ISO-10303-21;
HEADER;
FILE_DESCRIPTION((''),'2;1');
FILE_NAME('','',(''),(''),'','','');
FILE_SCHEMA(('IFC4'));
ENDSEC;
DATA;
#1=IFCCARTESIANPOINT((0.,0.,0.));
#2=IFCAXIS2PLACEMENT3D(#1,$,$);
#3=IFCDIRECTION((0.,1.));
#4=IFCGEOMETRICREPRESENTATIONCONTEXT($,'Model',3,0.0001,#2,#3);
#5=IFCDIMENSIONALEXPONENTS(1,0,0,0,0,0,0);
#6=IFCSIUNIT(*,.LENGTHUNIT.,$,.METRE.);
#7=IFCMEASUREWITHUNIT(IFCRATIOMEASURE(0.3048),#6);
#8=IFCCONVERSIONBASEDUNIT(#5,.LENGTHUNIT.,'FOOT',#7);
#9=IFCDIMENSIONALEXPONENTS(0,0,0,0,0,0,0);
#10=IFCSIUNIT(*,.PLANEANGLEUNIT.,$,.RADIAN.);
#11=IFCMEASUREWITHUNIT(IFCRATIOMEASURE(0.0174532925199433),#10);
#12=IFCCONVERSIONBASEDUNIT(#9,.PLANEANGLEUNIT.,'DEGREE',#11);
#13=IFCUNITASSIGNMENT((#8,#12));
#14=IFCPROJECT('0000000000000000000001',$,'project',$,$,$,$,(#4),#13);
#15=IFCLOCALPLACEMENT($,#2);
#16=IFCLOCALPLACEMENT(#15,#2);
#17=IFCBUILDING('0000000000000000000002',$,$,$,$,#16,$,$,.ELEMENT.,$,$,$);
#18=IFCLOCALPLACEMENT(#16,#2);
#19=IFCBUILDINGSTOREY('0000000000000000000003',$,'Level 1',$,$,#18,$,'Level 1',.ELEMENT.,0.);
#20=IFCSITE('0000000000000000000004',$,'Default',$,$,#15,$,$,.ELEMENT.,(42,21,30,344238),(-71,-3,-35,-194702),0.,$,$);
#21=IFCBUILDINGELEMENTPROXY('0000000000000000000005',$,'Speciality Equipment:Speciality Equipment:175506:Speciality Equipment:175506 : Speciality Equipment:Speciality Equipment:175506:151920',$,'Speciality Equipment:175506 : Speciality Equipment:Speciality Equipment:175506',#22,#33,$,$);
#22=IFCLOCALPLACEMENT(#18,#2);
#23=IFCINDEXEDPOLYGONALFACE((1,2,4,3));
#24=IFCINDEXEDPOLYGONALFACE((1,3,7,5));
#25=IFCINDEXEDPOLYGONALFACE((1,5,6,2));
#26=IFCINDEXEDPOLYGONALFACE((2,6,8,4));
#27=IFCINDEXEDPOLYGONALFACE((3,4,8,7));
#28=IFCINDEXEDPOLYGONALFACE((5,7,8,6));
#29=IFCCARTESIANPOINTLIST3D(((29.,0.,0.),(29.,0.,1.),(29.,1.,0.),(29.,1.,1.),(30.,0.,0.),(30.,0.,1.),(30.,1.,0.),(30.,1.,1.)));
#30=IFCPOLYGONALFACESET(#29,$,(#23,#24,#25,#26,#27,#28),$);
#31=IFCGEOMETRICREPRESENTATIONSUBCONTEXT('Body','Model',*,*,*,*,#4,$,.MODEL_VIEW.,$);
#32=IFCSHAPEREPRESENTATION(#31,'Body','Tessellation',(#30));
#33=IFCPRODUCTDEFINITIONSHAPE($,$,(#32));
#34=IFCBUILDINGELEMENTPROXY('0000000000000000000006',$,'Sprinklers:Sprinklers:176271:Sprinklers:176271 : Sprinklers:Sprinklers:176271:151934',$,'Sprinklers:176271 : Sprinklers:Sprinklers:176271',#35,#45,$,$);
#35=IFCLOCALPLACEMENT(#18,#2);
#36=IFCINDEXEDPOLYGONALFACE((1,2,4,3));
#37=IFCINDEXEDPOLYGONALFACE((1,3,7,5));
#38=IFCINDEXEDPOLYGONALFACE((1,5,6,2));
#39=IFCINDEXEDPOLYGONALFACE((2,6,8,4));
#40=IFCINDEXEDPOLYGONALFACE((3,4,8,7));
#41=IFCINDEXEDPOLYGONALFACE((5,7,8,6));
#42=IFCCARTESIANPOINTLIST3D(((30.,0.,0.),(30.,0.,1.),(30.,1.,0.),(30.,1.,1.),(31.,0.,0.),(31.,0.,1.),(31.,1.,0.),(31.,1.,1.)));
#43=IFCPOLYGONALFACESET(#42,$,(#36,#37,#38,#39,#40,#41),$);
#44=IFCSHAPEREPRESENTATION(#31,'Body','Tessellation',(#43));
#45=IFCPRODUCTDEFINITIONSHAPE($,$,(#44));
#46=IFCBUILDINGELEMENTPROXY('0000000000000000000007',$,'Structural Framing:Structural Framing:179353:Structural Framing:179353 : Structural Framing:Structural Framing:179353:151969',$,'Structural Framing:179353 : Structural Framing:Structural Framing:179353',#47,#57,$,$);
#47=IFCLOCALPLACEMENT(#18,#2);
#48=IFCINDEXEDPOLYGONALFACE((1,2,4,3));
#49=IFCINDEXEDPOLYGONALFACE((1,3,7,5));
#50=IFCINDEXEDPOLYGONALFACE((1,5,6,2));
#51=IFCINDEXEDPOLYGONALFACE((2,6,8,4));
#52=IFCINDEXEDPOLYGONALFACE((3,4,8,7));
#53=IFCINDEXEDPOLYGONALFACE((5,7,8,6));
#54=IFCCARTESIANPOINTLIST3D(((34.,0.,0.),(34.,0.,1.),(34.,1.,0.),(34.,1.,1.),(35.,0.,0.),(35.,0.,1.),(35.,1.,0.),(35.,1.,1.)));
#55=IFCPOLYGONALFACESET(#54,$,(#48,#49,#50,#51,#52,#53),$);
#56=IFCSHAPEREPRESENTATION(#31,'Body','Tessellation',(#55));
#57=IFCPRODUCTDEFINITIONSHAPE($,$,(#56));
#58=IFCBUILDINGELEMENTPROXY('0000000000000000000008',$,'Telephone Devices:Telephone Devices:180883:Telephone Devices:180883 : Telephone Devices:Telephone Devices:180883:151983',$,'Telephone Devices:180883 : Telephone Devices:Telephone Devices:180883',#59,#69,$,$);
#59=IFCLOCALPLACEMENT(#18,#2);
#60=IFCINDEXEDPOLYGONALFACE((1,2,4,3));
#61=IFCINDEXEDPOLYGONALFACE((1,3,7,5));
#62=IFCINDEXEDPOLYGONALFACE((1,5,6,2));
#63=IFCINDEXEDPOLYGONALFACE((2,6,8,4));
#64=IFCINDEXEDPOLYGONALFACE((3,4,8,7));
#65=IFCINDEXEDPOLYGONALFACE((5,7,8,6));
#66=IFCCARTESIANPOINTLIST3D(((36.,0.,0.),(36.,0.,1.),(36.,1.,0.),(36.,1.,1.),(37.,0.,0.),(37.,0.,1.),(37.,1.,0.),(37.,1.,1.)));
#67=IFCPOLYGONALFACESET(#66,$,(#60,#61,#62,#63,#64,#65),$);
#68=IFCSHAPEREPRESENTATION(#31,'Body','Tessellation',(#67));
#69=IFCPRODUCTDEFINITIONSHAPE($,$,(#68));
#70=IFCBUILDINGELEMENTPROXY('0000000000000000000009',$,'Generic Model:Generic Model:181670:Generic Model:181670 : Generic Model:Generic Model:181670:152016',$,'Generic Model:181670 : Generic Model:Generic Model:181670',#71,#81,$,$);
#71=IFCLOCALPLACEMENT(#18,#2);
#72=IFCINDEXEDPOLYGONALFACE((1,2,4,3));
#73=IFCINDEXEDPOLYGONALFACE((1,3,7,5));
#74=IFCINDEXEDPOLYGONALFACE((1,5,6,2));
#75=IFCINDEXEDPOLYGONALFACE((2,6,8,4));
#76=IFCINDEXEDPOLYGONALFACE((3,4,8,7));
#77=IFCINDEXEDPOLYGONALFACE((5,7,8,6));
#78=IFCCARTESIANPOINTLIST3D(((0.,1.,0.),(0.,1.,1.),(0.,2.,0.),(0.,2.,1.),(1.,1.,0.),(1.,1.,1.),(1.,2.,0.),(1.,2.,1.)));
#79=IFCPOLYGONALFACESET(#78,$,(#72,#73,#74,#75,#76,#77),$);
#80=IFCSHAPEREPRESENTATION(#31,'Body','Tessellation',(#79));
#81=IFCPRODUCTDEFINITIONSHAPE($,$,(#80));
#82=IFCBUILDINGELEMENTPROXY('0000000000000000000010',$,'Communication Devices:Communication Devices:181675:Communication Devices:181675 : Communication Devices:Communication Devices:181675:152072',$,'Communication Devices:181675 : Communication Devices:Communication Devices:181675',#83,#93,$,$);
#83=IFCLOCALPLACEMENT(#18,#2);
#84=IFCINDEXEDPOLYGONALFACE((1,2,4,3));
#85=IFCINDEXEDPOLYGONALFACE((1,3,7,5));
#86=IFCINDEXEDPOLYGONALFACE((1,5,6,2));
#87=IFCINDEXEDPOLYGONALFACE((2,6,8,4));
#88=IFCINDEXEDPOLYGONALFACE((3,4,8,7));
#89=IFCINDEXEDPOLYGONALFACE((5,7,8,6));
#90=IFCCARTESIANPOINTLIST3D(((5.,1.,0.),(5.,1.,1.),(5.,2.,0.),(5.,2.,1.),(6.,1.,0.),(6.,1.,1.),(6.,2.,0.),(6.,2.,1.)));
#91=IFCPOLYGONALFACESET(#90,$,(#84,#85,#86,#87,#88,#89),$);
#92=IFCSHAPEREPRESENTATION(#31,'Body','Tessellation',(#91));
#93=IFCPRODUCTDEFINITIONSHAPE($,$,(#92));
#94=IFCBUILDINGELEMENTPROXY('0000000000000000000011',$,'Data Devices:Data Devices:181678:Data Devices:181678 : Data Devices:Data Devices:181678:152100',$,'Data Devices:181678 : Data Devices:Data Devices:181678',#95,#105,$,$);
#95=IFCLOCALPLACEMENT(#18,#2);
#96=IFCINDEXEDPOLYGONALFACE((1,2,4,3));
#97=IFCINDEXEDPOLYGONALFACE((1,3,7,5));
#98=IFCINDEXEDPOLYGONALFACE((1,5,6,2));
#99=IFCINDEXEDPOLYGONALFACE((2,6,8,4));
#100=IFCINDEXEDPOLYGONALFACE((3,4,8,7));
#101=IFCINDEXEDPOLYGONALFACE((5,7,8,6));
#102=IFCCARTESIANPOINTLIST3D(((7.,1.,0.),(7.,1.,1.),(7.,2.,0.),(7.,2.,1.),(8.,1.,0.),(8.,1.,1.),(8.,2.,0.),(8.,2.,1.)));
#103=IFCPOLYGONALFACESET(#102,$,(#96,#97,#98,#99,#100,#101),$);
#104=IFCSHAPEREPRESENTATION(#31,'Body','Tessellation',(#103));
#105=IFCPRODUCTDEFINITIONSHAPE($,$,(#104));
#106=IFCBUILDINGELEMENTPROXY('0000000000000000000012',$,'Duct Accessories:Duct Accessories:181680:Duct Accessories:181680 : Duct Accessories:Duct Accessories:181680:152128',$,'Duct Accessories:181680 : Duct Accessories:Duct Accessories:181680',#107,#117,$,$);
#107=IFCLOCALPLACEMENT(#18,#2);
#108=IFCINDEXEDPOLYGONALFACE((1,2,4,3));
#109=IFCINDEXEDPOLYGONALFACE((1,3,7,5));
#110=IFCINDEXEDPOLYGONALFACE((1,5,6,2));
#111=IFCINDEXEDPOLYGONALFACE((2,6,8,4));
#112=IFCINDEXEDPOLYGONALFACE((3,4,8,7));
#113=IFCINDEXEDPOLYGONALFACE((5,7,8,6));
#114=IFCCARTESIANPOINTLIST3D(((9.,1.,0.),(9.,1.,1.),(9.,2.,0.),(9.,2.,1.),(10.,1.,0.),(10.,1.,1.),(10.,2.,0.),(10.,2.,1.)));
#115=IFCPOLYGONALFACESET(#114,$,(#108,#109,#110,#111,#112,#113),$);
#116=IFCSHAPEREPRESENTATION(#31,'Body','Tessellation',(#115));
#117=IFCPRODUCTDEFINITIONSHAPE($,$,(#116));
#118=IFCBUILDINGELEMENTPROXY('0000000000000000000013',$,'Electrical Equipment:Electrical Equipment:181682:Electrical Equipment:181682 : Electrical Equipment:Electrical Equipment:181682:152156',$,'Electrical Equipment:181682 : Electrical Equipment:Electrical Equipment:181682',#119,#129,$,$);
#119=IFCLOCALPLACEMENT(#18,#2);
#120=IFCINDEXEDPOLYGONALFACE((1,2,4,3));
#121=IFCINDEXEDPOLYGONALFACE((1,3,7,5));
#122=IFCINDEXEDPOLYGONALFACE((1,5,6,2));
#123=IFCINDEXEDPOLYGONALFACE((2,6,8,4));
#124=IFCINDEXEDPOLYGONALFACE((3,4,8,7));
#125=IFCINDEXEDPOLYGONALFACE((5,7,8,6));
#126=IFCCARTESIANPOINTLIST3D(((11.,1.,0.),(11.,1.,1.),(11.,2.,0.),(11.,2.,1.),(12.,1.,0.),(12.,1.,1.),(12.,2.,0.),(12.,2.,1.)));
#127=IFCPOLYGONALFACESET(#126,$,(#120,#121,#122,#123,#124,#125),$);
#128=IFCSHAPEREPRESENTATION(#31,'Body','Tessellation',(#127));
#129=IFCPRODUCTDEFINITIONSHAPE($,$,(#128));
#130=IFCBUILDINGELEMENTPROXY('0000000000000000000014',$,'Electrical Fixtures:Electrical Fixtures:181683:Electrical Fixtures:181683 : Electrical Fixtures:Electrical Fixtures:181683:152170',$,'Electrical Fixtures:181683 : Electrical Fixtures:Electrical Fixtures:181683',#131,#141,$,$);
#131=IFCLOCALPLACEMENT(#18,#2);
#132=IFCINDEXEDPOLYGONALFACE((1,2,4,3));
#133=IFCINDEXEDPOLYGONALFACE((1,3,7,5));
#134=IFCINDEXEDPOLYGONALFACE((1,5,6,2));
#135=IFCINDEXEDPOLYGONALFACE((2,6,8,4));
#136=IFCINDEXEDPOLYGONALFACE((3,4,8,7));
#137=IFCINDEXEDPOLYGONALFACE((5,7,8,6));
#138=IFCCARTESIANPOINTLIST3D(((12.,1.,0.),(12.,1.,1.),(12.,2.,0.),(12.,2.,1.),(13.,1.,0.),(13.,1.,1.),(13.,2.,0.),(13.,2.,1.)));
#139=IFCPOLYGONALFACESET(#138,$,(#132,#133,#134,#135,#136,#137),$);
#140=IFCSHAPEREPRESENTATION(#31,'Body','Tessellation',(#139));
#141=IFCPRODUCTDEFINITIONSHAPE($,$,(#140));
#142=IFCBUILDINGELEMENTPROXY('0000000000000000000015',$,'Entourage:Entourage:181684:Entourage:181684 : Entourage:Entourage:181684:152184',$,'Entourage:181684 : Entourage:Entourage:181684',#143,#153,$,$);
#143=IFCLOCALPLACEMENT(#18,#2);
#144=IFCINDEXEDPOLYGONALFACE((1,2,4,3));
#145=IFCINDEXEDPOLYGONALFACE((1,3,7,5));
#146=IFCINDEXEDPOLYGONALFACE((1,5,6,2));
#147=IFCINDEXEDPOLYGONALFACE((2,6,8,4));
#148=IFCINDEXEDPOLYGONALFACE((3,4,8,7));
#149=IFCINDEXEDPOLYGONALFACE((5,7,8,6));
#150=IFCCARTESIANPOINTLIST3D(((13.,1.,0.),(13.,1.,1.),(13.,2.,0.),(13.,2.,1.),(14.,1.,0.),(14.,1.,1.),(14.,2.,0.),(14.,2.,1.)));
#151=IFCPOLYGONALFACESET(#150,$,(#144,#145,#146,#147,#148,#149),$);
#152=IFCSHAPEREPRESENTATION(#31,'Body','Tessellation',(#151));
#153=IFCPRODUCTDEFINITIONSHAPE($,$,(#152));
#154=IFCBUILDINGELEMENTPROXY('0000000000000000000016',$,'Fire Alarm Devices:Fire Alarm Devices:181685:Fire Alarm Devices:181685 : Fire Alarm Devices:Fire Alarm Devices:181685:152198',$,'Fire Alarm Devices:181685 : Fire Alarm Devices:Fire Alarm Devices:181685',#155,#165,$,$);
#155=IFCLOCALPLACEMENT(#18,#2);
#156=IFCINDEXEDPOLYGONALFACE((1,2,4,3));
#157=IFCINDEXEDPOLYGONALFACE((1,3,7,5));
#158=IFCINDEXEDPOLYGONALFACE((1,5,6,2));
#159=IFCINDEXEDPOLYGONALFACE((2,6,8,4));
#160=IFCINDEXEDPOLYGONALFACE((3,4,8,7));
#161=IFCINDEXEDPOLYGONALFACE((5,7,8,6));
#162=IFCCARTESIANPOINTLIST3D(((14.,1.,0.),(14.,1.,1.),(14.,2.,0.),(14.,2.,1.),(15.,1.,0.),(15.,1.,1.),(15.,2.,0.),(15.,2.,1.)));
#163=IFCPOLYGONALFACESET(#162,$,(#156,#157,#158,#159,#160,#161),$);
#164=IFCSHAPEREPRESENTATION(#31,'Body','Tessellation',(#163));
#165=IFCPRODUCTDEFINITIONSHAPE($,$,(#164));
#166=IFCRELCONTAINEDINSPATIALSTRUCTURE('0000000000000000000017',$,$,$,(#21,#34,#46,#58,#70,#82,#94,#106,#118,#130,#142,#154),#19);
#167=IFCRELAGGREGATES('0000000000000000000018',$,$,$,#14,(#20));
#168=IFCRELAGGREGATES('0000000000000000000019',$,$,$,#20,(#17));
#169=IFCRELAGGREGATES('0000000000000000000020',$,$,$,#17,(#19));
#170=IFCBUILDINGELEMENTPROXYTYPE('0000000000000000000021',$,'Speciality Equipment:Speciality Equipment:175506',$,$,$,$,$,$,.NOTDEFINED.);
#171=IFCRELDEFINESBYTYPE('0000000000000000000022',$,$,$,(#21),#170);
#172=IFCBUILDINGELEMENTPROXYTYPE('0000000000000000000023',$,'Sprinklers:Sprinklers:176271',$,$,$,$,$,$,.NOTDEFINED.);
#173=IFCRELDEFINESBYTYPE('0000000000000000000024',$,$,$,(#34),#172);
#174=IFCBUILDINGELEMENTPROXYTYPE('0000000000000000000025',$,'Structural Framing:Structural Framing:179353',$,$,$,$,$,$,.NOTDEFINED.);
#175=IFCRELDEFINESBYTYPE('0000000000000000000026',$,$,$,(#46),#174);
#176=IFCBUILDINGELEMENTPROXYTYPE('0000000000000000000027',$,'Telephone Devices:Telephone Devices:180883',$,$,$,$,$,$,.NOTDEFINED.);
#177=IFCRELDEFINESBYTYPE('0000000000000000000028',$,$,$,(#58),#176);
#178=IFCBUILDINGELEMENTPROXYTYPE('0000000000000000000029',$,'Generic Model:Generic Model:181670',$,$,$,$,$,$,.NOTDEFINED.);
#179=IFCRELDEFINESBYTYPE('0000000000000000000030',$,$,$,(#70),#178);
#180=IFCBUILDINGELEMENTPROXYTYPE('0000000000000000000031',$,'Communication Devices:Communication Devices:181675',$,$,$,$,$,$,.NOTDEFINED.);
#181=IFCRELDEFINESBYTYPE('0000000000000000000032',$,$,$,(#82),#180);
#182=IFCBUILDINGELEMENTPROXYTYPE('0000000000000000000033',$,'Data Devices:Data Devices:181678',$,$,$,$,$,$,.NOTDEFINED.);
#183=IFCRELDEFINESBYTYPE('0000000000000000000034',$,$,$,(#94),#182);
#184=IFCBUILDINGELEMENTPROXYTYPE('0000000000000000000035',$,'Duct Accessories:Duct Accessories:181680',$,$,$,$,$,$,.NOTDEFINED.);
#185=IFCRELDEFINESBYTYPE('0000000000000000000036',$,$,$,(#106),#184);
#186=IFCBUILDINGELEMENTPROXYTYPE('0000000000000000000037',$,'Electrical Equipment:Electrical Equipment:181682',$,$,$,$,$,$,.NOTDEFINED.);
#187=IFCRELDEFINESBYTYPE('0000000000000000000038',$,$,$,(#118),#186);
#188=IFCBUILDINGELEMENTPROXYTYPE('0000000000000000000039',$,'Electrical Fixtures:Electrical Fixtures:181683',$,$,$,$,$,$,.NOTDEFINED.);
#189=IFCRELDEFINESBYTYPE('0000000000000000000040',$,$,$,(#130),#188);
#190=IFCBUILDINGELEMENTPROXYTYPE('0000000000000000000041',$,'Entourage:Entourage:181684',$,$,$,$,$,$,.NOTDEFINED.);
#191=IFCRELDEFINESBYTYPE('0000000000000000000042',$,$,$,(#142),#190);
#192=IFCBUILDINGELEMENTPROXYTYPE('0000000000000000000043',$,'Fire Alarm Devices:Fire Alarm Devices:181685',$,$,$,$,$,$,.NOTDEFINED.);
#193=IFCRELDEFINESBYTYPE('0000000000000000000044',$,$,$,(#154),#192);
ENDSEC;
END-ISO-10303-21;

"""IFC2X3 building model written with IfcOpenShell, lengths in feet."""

from ifc_helpers import new_model, entity, si_unit, converted_unit, direction, frame, frame_2d, origin, origin_2d_with_axis, place, context, subcontext, project, spatial, rectangle, extrude, source, transform, mapped, type_object, type_shapes, element, save


model = new_model("IFC2X3")

# Units and contexts
model_context = context("Model", 3, precision=0.0001, world=origin(), true_north=direction((0.0, 1.0)))
body_context = subcontext(model_context, "Body", "Model", "MODEL_VIEW")
ifc_project = project(units=[converted_unit("LENGTHUNIT", "FOOT", entity("IfcRatioMeasure", 0.3048), si_unit("LENGTHUNIT", "METRE"), dimensions=[1, 0, 0, 0, 0, 0, 0]), converted_unit("PLANEANGLEUNIT", "DEGREE", entity("IfcRatioMeasure", 0.0174532925199433), si_unit("PLANEANGLEUNIT", "RADIAN"), dimensions=[0, 0, 0, 0, 0, 0, 0])], contexts=[model_context])

# Site, building, storey
site_placement = place(None, origin())
site = spatial("IfcSite", under=ifc_project, at=site_placement, Name="Default", CompositionType="ELEMENT", RefLatitude=(42, 21, 30, 344238), RefLongitude=(-71, -3, -35, -194702), RefElevation=0.0)
building_placement = place(site_placement, origin())
building = spatial("IfcBuilding", under=site, at=building_placement, CompositionType="ELEMENT")
storey_placement = place(building_placement, origin())
storey = spatial("IfcBuildingStorey", under=building, at=storey_placement, Name="Level 1", LongName="Level 1", CompositionType="ELEMENT", Elevation=0.0)

# Building element proxies
building_element_proxy_type_1 = type_object("IfcBuildingElementProxyType", Name="Speciality Equipment:Speciality Equipment:175506", PredefinedType="NOTDEFINED")
shared_shape_1 = source(origin(), body_context, "Body", "SweptSolid", [
    extrude(rectangle(XDim=1.0, YDim=1.0, at=origin_2d_with_axis()), frame((29.5, 0.5, 0.0), z_axis=(0.0, 0.0, 1.0), x_axis=(-1.0, 0.0, 0.0)), (0.0, 0.0, 1.0), 1.0),
])
type_shapes(building_element_proxy_type_1, [shared_shape_1])
proxy_1_placement = place(storey_placement, origin())
element("IfcBuildingElementProxy", 1, at=proxy_1_placement, inside=storey, type_object=building_element_proxy_type_1, Name="Speciality Equipment:Speciality Equipment:175506:Speciality Equipment:175506 : Speciality Equipment:Speciality Equipment:175506:151920", ObjectType="Speciality Equipment:175506 : Speciality Equipment:Speciality Equipment:175506", context=body_context, shape_type="MappedRepresentation", body=[
    mapped(shared_shape_1, transform((0.0, 0.0, 0.0), scale=1.0)),
])
building_element_proxy_type_2 = type_object("IfcBuildingElementProxyType", Name="Sprinklers:Sprinklers:176271", PredefinedType="NOTDEFINED")
shared_shape_2 = source(origin(), body_context, "Body", "SweptSolid", [
    extrude(rectangle(XDim=1.0, YDim=1.0, at=origin_2d_with_axis()), frame((30.5, 0.5, 0.0), z_axis=(0.0, 0.0, 1.0), x_axis=(-1.0, 0.0, 0.0)), (0.0, 0.0, 1.0), 1.0),
])
type_shapes(building_element_proxy_type_2, [shared_shape_2])
proxy_2_placement = place(storey_placement, origin())
element("IfcBuildingElementProxy", 2, at=proxy_2_placement, inside=storey, type_object=building_element_proxy_type_2, Name="Sprinklers:Sprinklers:176271:Sprinklers:176271 : Sprinklers:Sprinklers:176271:151934", ObjectType="Sprinklers:176271 : Sprinklers:Sprinklers:176271", context=body_context, shape_type="MappedRepresentation", body=[
    mapped(shared_shape_2, transform((0.0, 0.0, 0.0), scale=1.0)),
])
building_element_proxy_type_3 = type_object("IfcBuildingElementProxyType", Name="Structural Framing:Structural Framing:179353", PredefinedType="NOTDEFINED")
shared_shape_3 = source(origin(), body_context, "Body", "SweptSolid", [
    extrude(rectangle(XDim=1.0, YDim=1.0, at=origin_2d_with_axis()), frame((34.5, 0.5, 0.0), z_axis=(0.0, 0.0, 1.0), x_axis=(-1.0, 0.0, 0.0)), (0.0, 0.0, 1.0), 1.0),
])
type_shapes(building_element_proxy_type_3, [shared_shape_3])
proxy_3_placement = place(storey_placement, origin())
element("IfcBuildingElementProxy", 3, at=proxy_3_placement, inside=storey, type_object=building_element_proxy_type_3, Name="Structural Framing:Structural Framing:179353:Structural Framing:179353 : Structural Framing:Structural Framing:179353:151969", ObjectType="Structural Framing:179353 : Structural Framing:Structural Framing:179353", context=body_context, shape_type="MappedRepresentation", body=[
    mapped(shared_shape_3, transform((0.0, 0.0, 0.0), scale=1.0)),
])
building_element_proxy_type_4 = type_object("IfcBuildingElementProxyType", Name="Telephone Devices:Telephone Devices:180883", PredefinedType="NOTDEFINED")
shared_shape_4 = source(origin(), body_context, "Body", "SweptSolid", [
    extrude(rectangle(XDim=1.0, YDim=1.0, at=origin_2d_with_axis()), frame((36.5, 0.5, 0.0), z_axis=(0.0, 0.0, 1.0), x_axis=(-1.0, 0.0, 0.0)), (0.0, 0.0, 1.0), 1.0),
])
type_shapes(building_element_proxy_type_4, [shared_shape_4])
proxy_4_placement = place(storey_placement, origin())
element("IfcBuildingElementProxy", 4, at=proxy_4_placement, inside=storey, type_object=building_element_proxy_type_4, Name="Telephone Devices:Telephone Devices:180883:Telephone Devices:180883 : Telephone Devices:Telephone Devices:180883:151983", ObjectType="Telephone Devices:180883 : Telephone Devices:Telephone Devices:180883", context=body_context, shape_type="MappedRepresentation", body=[
    mapped(shared_shape_4, transform((0.0, 0.0, 0.0), scale=1.0)),
])
building_element_proxy_type_5 = type_object("IfcBuildingElementProxyType", Name="Generic Model:Generic Model:181670", PredefinedType="NOTDEFINED")
shared_shape_5 = source(origin(), body_context, "Body", "SweptSolid", [
    extrude(rectangle(XDim=1.0, YDim=1.0, at=frame_2d((0.0, 0.0), x_axis=(1.0, 0.0))), frame((0.5, 1.5, 0.0), z_axis=(0.0, 0.0, 1.0), x_axis=(-1.0, 0.0, 0.0)), (0.0, 0.0, 1.0), 1.0),
])
type_shapes(building_element_proxy_type_5, [shared_shape_5])
proxy_5_placement = place(storey_placement, origin())
element("IfcBuildingElementProxy", 5, at=proxy_5_placement, inside=storey, type_object=building_element_proxy_type_5, Name="Generic Model:Generic Model:181670:Generic Model:181670 : Generic Model:Generic Model:181670:152016", ObjectType="Generic Model:181670 : Generic Model:Generic Model:181670", context=body_context, shape_type="MappedRepresentation", body=[
    mapped(shared_shape_5, transform((0.0, 0.0, 0.0), scale=1.0)),
])
building_element_proxy_type_6 = type_object("IfcBuildingElementProxyType", Name="Communication Devices:Communication Devices:181675", PredefinedType="NOTDEFINED")
shared_shape_6 = source(origin(), body_context, "Body", "SweptSolid", [
    extrude(rectangle(XDim=1.0, YDim=1.0, at=frame_2d((0.0, 0.0), x_axis=(1.0, 0.0))), frame((5.5, 1.5, 0.0), z_axis=(0.0, 0.0, 1.0), x_axis=(-1.0, 0.0, 0.0)), (0.0, 0.0, 1.0), 1.0),
])
type_shapes(building_element_proxy_type_6, [shared_shape_6])
proxy_6_placement = place(storey_placement, origin())
element("IfcBuildingElementProxy", 6, at=proxy_6_placement, inside=storey, type_object=building_element_proxy_type_6, Name="Communication Devices:Communication Devices:181675:Communication Devices:181675 : Communication Devices:Communication Devices:181675:152072", ObjectType="Communication Devices:181675 : Communication Devices:Communication Devices:181675", context=body_context, shape_type="MappedRepresentation", body=[
    mapped(shared_shape_6, transform((0.0, 0.0, 0.0), scale=1.0)),
])
building_element_proxy_type_7 = type_object("IfcBuildingElementProxyType", Name="Data Devices:Data Devices:181678", PredefinedType="NOTDEFINED")
shared_shape_7 = source(origin(), body_context, "Body", "SweptSolid", [
    extrude(rectangle(XDim=1.0, YDim=1.0, at=frame_2d((0.0, 0.0), x_axis=(1.0, 0.0))), frame((7.5, 1.5, 0.0), z_axis=(0.0, 0.0, 1.0), x_axis=(-1.0, 0.0, 0.0)), (0.0, 0.0, 1.0), 1.0),
])
type_shapes(building_element_proxy_type_7, [shared_shape_7])
proxy_7_placement = place(storey_placement, origin())
element("IfcBuildingElementProxy", 7, at=proxy_7_placement, inside=storey, type_object=building_element_proxy_type_7, Name="Data Devices:Data Devices:181678:Data Devices:181678 : Data Devices:Data Devices:181678:152100", ObjectType="Data Devices:181678 : Data Devices:Data Devices:181678", context=body_context, shape_type="MappedRepresentation", body=[
    mapped(shared_shape_7, transform((0.0, 0.0, 0.0), scale=1.0)),
])
building_element_proxy_type_8 = type_object("IfcBuildingElementProxyType", Name="Duct Accessories:Duct Accessories:181680", PredefinedType="NOTDEFINED")
shared_shape_8 = source(origin(), body_context, "Body", "SweptSolid", [
    extrude(rectangle(XDim=1.0, YDim=1.0, at=frame_2d((0.0, 0.0), x_axis=(1.0, 0.0))), frame((9.5, 1.5, 0.0), z_axis=(0.0, 0.0, 1.0), x_axis=(-1.0, 0.0, 0.0)), (0.0, 0.0, 1.0), 1.0),
])
type_shapes(building_element_proxy_type_8, [shared_shape_8])
proxy_8_placement = place(storey_placement, origin())
element("IfcBuildingElementProxy", 8, at=proxy_8_placement, inside=storey, type_object=building_element_proxy_type_8, Name="Duct Accessories:Duct Accessories:181680:Duct Accessories:181680 : Duct Accessories:Duct Accessories:181680:152128", ObjectType="Duct Accessories:181680 : Duct Accessories:Duct Accessories:181680", context=body_context, shape_type="MappedRepresentation", body=[
    mapped(shared_shape_8, transform((0.0, 0.0, 0.0), scale=1.0)),
])
building_element_proxy_type_9 = type_object("IfcBuildingElementProxyType", Name="Electrical Equipment:Electrical Equipment:181682", PredefinedType="NOTDEFINED")
shared_shape_9 = source(origin(), body_context, "Body", "SweptSolid", [
    extrude(rectangle(XDim=1.0, YDim=1.0, at=frame_2d((0.0, 0.0), x_axis=(1.0, 0.0))), frame((11.5, 1.5, 0.0), z_axis=(0.0, 0.0, 1.0), x_axis=(-1.0, 0.0, 0.0)), (0.0, 0.0, 1.0), 1.0),
])
type_shapes(building_element_proxy_type_9, [shared_shape_9])
proxy_9_placement = place(storey_placement, origin())
element("IfcBuildingElementProxy", 9, at=proxy_9_placement, inside=storey, type_object=building_element_proxy_type_9, Name="Electrical Equipment:Electrical Equipment:181682:Electrical Equipment:181682 : Electrical Equipment:Electrical Equipment:181682:152156", ObjectType="Electrical Equipment:181682 : Electrical Equipment:Electrical Equipment:181682", context=body_context, shape_type="MappedRepresentation", body=[
    mapped(shared_shape_9, transform((0.0, 0.0, 0.0), scale=1.0)),
])
building_element_proxy_type_10 = type_object("IfcBuildingElementProxyType", Name="Electrical Fixtures:Electrical Fixtures:181683", PredefinedType="NOTDEFINED")
shared_shape_10 = source(origin(), body_context, "Body", "SweptSolid", [
    extrude(rectangle(XDim=1.0, YDim=1.0, at=frame_2d((0.0, 0.0), x_axis=(1.0, 0.0))), frame((12.5, 1.5, 0.0), z_axis=(0.0, 0.0, 1.0), x_axis=(-1.0, 0.0, 0.0)), (0.0, 0.0, 1.0), 1.0),
])
type_shapes(building_element_proxy_type_10, [shared_shape_10])
proxy_10_placement = place(storey_placement, origin())
element("IfcBuildingElementProxy", 10, at=proxy_10_placement, inside=storey, type_object=building_element_proxy_type_10, Name="Electrical Fixtures:Electrical Fixtures:181683:Electrical Fixtures:181683 : Electrical Fixtures:Electrical Fixtures:181683:152170", ObjectType="Electrical Fixtures:181683 : Electrical Fixtures:Electrical Fixtures:181683", context=body_context, shape_type="MappedRepresentation", body=[
    mapped(shared_shape_10, transform((0.0, 0.0, 0.0), scale=1.0)),
])
building_element_proxy_type_11 = type_object("IfcBuildingElementProxyType", Name="Entourage:Entourage:181684", PredefinedType="NOTDEFINED")
shared_shape_11 = source(origin(), body_context, "Body", "SweptSolid", [
    extrude(rectangle(XDim=1.0, YDim=1.0, at=frame_2d((0.0, 0.0), x_axis=(1.0, 0.0))), frame((13.5, 1.5, 0.0), z_axis=(0.0, 0.0, 1.0), x_axis=(-1.0, 0.0, 0.0)), (0.0, 0.0, 1.0), 1.0),
])
type_shapes(building_element_proxy_type_11, [shared_shape_11])
proxy_11_placement = place(storey_placement, origin())
element("IfcBuildingElementProxy", 11, at=proxy_11_placement, inside=storey, type_object=building_element_proxy_type_11, Name="Entourage:Entourage:181684:Entourage:181684 : Entourage:Entourage:181684:152184", ObjectType="Entourage:181684 : Entourage:Entourage:181684", context=body_context, shape_type="MappedRepresentation", body=[
    mapped(shared_shape_11, transform((0.0, 0.0, 0.0), scale=1.0)),
])
building_element_proxy_type_12 = type_object("IfcBuildingElementProxyType", Name="Fire Alarm Devices:Fire Alarm Devices:181685", PredefinedType="NOTDEFINED")
shared_shape_12 = source(origin(), body_context, "Body", "SweptSolid", [
    extrude(rectangle(XDim=1.0, YDim=1.0, at=frame_2d((0.0, 0.0), x_axis=(1.0, 0.0))), frame((14.5, 1.5, 0.0), z_axis=(0.0, 0.0, 1.0), x_axis=(-1.0, 0.0, 0.0)), (0.0, 0.0, 1.0), 1.0),
])
type_shapes(building_element_proxy_type_12, [shared_shape_12])
proxy_12_placement = place(storey_placement, origin())
element("IfcBuildingElementProxy", 12, at=proxy_12_placement, inside=storey, type_object=building_element_proxy_type_12, Name="Fire Alarm Devices:Fire Alarm Devices:181685:Fire Alarm Devices:181685 : Fire Alarm Devices:Fire Alarm Devices:181685:152198", ObjectType="Fire Alarm Devices:181685 : Fire Alarm Devices:Fire Alarm Devices:181685", context=body_context, shape_type="MappedRepresentation", body=[
    mapped(shared_shape_12, transform((0.0, 0.0, 0.0), scale=1.0)),
])

save(model, "model.ifc")
